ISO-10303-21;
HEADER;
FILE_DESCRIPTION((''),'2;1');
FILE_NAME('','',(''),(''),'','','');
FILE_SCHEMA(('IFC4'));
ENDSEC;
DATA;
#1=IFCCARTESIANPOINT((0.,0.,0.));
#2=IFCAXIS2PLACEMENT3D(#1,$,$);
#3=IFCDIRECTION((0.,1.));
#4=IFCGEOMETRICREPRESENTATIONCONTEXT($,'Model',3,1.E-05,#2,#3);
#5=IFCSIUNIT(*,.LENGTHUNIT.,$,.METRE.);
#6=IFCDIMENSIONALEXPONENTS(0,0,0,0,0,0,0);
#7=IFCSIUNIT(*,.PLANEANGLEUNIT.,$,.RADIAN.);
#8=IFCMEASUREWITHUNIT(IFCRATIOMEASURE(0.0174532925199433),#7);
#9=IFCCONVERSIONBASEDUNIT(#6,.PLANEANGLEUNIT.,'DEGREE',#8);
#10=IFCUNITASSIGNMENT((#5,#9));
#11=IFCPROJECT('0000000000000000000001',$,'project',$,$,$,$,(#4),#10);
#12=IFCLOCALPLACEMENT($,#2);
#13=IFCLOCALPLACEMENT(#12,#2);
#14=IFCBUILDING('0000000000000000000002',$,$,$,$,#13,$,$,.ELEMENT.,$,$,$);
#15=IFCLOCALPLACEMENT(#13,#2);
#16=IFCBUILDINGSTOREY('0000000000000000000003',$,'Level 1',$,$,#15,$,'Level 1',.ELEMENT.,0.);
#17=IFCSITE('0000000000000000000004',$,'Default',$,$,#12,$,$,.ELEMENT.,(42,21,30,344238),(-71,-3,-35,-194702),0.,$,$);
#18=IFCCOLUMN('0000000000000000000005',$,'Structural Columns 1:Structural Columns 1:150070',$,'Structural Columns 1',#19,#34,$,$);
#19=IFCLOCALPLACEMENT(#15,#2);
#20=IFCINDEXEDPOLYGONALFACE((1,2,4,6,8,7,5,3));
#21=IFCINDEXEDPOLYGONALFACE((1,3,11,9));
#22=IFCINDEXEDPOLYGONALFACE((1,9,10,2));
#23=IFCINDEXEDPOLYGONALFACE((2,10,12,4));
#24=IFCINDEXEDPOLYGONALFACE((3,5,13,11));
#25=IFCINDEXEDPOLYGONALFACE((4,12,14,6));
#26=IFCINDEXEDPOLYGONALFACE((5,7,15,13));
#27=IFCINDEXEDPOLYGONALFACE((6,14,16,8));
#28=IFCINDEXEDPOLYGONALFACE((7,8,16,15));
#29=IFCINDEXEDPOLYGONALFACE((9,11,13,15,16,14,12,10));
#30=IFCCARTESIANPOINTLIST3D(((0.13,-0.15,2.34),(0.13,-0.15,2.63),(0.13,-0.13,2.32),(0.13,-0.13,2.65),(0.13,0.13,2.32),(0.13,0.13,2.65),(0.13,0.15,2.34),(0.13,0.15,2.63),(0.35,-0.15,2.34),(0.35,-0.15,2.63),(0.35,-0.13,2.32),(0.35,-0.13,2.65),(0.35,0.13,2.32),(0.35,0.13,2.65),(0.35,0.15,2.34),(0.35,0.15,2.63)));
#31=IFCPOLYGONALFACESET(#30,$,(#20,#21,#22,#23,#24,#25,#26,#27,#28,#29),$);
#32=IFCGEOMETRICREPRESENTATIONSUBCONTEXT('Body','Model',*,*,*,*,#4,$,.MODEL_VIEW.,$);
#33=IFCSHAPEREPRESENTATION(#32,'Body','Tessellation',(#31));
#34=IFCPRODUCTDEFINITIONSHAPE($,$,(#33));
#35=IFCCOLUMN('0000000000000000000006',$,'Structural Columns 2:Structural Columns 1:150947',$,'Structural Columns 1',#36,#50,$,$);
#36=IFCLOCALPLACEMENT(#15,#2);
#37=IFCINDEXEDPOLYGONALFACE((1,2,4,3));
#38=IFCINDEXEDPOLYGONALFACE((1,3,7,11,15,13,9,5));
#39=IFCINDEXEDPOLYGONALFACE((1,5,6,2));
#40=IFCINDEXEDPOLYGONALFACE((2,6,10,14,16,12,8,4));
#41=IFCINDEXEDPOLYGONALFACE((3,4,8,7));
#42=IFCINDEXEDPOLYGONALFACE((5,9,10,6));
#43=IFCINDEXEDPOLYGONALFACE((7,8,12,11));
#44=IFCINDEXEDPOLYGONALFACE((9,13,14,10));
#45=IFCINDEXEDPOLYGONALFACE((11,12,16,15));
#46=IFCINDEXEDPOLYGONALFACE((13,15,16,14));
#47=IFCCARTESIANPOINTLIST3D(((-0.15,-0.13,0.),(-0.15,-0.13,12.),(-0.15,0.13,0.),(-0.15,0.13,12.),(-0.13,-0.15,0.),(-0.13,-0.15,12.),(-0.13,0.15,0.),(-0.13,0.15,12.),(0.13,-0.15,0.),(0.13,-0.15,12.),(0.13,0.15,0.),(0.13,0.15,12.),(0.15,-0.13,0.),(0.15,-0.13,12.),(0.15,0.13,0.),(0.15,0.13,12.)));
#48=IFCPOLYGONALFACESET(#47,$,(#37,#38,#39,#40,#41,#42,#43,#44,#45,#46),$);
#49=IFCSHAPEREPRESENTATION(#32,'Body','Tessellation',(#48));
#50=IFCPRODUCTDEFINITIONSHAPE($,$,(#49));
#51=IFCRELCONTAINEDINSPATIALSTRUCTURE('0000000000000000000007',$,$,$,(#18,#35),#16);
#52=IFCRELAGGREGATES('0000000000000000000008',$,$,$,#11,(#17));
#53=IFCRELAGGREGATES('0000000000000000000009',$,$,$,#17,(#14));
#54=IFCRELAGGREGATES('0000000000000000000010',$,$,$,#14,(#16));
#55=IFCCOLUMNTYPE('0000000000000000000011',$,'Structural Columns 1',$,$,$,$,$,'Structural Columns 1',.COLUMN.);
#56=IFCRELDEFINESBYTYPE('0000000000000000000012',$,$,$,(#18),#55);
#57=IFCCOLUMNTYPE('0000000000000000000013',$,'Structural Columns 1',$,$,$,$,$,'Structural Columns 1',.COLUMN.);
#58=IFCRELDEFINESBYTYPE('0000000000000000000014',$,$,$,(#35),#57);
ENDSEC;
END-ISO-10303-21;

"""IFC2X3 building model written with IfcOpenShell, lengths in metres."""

from ifc_helpers import new_model, entity, si_unit, converted_unit, direction, frame, frame_2d, origin, place, context, subcontext, project, spatial, polyline, rectangle, outline, extrude, clip, halfspace, source, transform, mapped, type_object, type_shapes, element, save


model = new_model("IFC2X3")

# Units and contexts
model_context = context("Model", 3, precision=1e-05, world=origin(), true_north=direction((0.0, 1.0)))
body_context = subcontext(model_context, "Body", "Model", "MODEL_VIEW")
ifc_project = project(units=[si_unit("LENGTHUNIT", "METRE"), converted_unit("PLANEANGLEUNIT", "DEGREE", entity("IfcRatioMeasure", 0.0174532925199433), si_unit("PLANEANGLEUNIT", "RADIAN"), dimensions=[0, 0, 0, 0, 0, 0, 0])], contexts=[model_context])

# Site, building, storey
site_placement = place(None, origin())
site = spatial("IfcSite", under=ifc_project, at=site_placement, Name="Default", CompositionType="ELEMENT", RefLatitude=(42, 21, 30, 344238), RefLongitude=(-71, -3, -35, -194702), RefElevation=0.0)
building_placement = place(site_placement, origin())
building = spatial("IfcBuilding", under=site, at=building_placement, CompositionType="ELEMENT")
storey_placement = place(building_placement, origin())
storey = spatial("IfcBuildingStorey", under=building, at=storey_placement, Name="Level 1", LongName="Level 1", CompositionType="ELEMENT", Elevation=0.0)

# Columns
column_type_1 = type_object("IfcColumnType", Name="Structural Columns 1", ElementType="Structural Columns 1", PredefinedType="COLUMN")
shared_shape_1 = source(origin(), body_context, "Body", "Clipping", [
    clip(clip(clip(clip(extrude(rectangle(XDim=0.22, YDim=0.3, at=frame_2d((0.0, 0.0), x_axis=(1.0, 0.0))), frame((0.24, 0.0, 2.32)), (0.0, 0.0, 1.0), 0.33), halfspace(frame((0.35, -0.15, 2.34), z_axis=(0.0, -0.707107, -0.707107), x_axis=(1.0, 0.0, 0.0)), False)), halfspace(frame((0.35, 0.13, 2.32), z_axis=(0.0, 0.707107, -0.707107), x_axis=(1.0, 0.0, 0.0)), False)), halfspace(frame((0.35, 0.15, 2.63), z_axis=(0.0, 0.707107, 0.707107), x_axis=(1.0, 0.0, 0.0)), False)), halfspace(frame((0.35, -0.13, 2.65), z_axis=(0.0, -0.707107, 0.707107), x_axis=(1.0, 0.0, 0.0)), False)),
])
type_shapes(column_type_1, [shared_shape_1])
column_1_placement = place(storey_placement, origin())
element("IfcColumn", 1, at=column_1_placement, inside=storey, type_object=column_type_1, Name="Structural Columns 1:Structural Columns 1:150070", ObjectType="Structural Columns 1", context=body_context, shape_type="MappedRepresentation", body=[
    mapped(shared_shape_1, transform((0.0, 0.0, 0.0), scale=1.0)),
])
column_type_2 = type_object("IfcColumnType", Name="Structural Columns 1", ElementType="Structural Columns 1", PredefinedType="COLUMN")
shared_shape_2 = source(origin(), body_context, "Body", "SweptSolid", [
    extrude(outline(polyline([(-0.13, -0.15), (0.13, -0.15), (0.15, -0.13), (0.15, 0.13), (0.13, 0.15), (-0.13, 0.15), (-0.15, 0.13), (-0.15, -0.13), (-0.13, -0.15)])), frame((0.0, 0.0, 0.0), z_axis=(0.0, 0.0, 1.0), x_axis=(0.0, -1.0, 0.0)), (0.0, 0.0, 1.0), 12.0),
])
type_shapes(column_type_2, [shared_shape_2])
column_2_placement = place(storey_placement, origin())
element("IfcColumn", 2, at=column_2_placement, inside=storey, type_object=column_type_2, Name="Structural Columns 2:Structural Columns 1:150947", ObjectType="Structural Columns 1", context=body_context, shape_type="MappedRepresentation", body=[
    mapped(shared_shape_2, transform((0.0, 0.0, 0.0), scale=1.0)),
])

save(model, "model.ifc")
